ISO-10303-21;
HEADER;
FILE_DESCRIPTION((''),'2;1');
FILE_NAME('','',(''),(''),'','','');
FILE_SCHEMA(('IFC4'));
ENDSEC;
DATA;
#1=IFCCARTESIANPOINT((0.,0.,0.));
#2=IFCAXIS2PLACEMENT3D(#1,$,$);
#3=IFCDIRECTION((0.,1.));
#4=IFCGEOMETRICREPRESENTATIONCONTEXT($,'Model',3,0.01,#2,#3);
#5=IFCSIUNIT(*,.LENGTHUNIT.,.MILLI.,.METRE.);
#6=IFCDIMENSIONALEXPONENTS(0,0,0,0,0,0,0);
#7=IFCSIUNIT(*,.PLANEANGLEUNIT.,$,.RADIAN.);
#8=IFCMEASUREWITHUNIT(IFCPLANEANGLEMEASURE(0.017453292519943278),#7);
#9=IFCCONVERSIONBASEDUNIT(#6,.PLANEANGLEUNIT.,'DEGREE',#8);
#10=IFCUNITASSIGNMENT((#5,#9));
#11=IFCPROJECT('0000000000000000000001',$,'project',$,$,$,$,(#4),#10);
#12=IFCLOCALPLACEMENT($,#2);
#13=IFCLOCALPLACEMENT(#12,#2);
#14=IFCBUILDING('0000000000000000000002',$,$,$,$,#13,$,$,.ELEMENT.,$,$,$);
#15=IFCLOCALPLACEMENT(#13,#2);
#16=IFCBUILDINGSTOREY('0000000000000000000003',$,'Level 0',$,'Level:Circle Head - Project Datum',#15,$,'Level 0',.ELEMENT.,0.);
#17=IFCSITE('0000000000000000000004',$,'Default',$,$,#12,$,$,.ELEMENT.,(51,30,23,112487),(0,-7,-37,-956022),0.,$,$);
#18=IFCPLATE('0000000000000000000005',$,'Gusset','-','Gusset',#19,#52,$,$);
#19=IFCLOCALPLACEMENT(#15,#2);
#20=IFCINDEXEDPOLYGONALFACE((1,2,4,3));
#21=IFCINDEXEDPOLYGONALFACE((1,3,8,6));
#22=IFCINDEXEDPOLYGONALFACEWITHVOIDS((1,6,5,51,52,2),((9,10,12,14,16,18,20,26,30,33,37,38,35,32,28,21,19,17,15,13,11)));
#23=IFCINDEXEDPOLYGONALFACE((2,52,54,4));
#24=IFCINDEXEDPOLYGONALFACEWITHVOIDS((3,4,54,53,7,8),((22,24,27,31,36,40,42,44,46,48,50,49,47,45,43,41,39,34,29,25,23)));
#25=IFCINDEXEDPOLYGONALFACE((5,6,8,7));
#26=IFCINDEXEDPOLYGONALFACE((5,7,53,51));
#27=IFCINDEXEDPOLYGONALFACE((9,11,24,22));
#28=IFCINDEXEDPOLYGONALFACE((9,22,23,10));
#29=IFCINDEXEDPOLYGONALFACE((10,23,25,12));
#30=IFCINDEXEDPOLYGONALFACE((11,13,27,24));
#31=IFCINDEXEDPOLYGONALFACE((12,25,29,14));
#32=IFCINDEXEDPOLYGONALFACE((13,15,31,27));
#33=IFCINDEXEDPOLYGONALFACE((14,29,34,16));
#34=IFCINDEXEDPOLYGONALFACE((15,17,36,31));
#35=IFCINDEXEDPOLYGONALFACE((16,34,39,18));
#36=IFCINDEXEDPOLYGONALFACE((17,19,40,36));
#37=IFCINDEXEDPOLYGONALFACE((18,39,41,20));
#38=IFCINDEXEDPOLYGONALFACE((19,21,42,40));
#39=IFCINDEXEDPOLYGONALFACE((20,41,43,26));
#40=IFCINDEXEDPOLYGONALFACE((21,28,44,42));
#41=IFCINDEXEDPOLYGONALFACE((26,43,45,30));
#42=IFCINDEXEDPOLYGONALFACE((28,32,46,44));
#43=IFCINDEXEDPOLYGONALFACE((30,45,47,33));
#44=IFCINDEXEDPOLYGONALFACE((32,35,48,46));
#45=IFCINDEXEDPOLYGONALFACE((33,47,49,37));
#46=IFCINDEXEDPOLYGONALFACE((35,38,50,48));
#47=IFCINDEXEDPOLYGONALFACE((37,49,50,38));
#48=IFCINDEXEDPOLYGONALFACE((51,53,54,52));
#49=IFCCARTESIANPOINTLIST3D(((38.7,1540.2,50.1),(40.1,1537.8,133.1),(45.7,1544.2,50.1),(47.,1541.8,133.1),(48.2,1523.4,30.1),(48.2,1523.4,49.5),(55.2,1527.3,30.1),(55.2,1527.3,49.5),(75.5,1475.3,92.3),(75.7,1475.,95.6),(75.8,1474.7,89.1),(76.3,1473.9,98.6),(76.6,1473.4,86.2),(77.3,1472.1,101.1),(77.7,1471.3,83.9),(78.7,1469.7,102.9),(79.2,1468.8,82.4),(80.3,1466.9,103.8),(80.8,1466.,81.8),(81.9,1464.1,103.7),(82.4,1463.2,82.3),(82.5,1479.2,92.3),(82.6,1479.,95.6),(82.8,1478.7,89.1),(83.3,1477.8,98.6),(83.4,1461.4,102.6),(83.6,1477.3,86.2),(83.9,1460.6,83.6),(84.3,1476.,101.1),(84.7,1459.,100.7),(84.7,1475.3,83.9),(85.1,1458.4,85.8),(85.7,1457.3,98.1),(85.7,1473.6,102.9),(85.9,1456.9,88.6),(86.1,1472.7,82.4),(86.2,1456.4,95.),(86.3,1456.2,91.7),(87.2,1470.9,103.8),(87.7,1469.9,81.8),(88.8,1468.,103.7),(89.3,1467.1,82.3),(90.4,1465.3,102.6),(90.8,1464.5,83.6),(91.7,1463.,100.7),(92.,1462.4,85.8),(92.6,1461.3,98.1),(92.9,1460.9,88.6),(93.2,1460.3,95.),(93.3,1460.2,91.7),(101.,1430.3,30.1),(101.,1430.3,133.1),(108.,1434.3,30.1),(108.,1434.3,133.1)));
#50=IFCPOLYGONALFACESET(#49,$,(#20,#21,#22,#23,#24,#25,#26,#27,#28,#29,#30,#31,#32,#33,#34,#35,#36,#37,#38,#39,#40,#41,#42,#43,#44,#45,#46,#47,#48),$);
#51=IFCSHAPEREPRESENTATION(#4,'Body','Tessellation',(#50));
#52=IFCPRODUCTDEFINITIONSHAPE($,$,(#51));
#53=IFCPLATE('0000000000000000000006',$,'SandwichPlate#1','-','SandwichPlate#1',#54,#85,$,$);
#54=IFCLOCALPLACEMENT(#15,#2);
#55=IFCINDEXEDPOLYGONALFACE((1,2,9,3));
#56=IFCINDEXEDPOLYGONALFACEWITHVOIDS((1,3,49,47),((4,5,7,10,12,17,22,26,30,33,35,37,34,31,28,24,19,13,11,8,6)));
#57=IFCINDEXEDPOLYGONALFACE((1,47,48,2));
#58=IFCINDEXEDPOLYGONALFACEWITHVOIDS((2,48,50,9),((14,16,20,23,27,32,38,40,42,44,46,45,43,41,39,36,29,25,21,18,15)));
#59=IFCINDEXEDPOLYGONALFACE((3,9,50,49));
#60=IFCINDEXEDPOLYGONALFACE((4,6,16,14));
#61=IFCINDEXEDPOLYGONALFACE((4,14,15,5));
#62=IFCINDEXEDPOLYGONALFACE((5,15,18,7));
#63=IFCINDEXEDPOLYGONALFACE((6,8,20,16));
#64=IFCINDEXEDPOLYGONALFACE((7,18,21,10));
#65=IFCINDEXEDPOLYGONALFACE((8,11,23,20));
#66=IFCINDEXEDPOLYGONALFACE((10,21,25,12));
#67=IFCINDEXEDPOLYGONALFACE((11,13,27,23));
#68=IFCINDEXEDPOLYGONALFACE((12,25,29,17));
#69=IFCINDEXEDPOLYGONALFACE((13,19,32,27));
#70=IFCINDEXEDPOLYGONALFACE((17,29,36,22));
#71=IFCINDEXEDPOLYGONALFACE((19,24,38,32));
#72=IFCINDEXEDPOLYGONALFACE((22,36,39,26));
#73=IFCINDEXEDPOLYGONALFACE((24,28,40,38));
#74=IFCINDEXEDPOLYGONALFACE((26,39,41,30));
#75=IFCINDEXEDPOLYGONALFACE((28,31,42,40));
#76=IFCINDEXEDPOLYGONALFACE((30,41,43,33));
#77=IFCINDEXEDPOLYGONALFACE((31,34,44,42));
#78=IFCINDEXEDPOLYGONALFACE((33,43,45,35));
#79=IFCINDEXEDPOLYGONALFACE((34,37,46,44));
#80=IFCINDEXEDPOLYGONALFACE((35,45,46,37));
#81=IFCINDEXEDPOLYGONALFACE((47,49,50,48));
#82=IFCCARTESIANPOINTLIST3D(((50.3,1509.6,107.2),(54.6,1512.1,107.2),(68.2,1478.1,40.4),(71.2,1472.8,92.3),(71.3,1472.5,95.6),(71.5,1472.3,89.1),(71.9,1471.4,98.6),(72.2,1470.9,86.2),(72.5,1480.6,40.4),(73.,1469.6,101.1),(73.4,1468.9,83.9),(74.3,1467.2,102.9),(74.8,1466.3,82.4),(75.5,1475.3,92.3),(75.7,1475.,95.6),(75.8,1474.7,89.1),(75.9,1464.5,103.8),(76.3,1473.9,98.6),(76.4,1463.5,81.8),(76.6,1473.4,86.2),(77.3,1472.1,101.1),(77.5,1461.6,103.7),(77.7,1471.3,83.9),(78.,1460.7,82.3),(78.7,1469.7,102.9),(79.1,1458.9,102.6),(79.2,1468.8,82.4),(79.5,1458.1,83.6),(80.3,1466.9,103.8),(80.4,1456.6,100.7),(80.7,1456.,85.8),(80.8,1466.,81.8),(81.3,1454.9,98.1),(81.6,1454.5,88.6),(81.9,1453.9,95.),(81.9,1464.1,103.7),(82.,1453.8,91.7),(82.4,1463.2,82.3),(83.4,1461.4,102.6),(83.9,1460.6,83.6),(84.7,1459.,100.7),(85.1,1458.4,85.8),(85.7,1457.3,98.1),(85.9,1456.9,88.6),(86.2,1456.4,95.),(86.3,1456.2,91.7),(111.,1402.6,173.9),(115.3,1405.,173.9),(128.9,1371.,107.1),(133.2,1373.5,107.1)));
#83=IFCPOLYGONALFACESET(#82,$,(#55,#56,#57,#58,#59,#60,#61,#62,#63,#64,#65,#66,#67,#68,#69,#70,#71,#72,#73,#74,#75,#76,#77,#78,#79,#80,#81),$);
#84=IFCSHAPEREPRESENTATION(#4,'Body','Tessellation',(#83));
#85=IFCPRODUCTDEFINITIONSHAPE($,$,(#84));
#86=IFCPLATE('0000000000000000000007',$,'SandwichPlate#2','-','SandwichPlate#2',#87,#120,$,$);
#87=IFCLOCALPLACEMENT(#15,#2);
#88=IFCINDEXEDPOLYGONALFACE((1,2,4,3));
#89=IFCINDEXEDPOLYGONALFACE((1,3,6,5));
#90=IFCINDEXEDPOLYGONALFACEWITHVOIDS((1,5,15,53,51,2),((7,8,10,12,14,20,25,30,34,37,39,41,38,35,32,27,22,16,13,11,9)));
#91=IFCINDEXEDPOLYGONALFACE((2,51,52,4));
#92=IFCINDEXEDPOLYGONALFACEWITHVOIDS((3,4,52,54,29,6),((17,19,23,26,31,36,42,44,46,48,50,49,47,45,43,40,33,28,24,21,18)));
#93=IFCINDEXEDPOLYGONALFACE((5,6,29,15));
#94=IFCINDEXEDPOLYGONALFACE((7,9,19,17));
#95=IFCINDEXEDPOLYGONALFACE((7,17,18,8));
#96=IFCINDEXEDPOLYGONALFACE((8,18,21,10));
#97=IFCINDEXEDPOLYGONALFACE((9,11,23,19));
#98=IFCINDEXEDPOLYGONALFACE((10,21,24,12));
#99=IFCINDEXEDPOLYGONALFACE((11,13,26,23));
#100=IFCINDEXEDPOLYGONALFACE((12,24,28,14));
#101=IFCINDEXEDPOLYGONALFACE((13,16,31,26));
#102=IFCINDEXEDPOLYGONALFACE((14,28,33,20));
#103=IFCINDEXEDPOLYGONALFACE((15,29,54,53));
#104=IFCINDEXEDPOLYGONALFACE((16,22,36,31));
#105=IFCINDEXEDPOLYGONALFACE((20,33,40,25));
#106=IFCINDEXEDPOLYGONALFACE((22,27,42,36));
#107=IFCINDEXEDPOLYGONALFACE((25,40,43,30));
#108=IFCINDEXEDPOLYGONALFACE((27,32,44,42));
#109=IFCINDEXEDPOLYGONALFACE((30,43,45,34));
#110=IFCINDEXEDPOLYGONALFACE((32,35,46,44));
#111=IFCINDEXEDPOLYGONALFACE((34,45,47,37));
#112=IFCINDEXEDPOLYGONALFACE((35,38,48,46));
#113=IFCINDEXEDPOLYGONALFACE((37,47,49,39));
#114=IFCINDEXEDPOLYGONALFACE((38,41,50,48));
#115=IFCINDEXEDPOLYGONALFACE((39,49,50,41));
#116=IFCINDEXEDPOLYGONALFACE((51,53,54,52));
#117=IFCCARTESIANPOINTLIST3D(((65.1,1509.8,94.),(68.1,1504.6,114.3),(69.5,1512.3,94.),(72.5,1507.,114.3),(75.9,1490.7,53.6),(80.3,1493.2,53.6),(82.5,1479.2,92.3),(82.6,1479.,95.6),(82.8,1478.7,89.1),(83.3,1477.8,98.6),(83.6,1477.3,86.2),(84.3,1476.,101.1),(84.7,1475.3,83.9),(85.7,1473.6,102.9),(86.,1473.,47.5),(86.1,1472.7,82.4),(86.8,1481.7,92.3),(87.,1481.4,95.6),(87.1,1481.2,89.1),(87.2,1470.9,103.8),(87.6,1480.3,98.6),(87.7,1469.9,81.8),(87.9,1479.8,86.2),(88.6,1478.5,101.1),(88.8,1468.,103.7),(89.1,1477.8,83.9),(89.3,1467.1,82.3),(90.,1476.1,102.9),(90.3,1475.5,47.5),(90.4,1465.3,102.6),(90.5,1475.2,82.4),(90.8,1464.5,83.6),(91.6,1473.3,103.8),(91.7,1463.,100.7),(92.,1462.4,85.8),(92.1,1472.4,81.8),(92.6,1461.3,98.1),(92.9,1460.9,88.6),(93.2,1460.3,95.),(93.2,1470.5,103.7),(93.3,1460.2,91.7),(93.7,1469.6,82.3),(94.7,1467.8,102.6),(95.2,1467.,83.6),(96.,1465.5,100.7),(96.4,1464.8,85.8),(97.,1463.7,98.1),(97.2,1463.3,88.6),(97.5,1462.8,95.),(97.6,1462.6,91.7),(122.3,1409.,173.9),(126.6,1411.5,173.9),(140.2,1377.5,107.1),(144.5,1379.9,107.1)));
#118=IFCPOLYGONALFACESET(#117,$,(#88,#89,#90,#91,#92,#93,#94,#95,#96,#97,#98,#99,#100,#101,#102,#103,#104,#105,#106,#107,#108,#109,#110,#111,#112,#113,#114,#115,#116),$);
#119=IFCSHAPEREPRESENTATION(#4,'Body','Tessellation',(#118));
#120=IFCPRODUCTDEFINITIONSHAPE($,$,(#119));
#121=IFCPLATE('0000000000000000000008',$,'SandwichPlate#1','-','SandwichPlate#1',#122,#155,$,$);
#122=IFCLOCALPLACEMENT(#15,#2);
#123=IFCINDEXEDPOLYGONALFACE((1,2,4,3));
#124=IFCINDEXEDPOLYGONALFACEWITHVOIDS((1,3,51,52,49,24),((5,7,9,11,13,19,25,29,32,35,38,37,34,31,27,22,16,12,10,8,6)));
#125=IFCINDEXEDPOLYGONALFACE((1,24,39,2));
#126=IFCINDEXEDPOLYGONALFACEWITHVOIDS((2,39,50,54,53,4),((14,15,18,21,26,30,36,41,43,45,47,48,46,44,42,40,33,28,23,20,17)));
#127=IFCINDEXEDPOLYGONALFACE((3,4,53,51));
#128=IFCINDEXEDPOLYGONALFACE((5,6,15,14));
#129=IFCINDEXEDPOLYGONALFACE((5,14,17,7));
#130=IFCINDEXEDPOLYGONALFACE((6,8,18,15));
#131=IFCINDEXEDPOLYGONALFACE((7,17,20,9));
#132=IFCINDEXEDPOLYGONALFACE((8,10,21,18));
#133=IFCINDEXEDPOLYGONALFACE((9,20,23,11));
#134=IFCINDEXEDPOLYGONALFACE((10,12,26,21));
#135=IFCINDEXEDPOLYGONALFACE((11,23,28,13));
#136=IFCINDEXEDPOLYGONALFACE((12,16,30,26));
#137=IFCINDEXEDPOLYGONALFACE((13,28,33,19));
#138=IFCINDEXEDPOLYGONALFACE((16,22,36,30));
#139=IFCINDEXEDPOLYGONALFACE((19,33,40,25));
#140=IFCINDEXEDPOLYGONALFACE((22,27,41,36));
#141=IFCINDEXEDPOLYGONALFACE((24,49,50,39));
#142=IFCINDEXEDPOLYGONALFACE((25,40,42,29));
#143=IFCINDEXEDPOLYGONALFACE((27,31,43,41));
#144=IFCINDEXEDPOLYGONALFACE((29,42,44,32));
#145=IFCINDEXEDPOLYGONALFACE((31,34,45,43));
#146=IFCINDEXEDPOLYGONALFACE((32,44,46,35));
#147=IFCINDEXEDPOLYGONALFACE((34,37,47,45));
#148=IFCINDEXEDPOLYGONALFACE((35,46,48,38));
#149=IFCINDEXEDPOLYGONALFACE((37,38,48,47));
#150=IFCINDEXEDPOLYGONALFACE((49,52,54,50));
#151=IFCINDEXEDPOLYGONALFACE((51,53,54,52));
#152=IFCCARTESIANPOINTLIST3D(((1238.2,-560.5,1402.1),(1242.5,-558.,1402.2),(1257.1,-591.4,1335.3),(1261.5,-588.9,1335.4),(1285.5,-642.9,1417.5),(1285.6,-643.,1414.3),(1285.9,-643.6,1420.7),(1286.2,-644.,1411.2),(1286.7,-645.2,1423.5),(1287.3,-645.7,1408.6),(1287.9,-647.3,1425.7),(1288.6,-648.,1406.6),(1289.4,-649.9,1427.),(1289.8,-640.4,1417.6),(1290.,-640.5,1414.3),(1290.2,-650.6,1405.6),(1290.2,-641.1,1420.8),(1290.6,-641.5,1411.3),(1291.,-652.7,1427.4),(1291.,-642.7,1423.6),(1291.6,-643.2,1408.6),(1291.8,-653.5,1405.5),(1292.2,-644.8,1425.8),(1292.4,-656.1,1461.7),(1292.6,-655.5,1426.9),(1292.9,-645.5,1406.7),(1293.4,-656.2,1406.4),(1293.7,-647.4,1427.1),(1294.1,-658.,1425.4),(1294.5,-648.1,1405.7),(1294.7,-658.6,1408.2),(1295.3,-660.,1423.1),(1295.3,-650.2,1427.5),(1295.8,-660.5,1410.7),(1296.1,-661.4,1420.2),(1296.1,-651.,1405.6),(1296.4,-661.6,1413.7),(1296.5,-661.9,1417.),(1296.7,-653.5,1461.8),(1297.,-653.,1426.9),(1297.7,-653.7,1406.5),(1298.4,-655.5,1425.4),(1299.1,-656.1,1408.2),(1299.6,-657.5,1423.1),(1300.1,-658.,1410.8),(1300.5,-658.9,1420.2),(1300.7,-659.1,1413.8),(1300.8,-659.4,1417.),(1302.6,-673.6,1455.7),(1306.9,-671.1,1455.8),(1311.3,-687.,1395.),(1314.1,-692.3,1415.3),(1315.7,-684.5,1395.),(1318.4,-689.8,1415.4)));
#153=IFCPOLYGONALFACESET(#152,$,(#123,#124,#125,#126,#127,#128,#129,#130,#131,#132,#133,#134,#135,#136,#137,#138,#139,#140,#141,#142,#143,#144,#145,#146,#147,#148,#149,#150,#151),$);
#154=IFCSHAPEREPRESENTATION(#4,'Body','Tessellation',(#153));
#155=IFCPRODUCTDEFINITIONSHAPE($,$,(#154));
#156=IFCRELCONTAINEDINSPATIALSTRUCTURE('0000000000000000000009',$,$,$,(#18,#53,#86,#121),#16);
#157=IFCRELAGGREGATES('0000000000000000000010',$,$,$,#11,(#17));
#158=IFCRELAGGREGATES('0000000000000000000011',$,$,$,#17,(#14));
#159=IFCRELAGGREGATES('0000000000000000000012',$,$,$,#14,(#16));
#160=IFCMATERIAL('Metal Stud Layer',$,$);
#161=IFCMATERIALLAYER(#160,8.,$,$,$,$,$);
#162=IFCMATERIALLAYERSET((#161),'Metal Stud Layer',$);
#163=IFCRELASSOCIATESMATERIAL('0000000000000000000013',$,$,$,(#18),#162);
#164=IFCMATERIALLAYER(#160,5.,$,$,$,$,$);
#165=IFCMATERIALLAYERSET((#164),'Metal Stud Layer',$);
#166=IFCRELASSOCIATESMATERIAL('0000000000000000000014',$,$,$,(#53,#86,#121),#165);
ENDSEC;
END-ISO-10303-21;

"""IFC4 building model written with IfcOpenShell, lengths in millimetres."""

from ifc_helpers import new_model, entity, si_unit, converted_unit, point, direction, frame, frame_2d, origin, origin_with_axes, origin_2d_with_axis, place, context, project, spatial, polyline, circle_curve, line_curve, trimmed, segment, composite_curve, circle, outline, extrude, material, layer, layer_set, element, save


model = new_model("IFC4")

# Units and contexts
model_context = context("Model", 3, precision=0.01, world=origin(), true_north=direction((0.0, 1.0)))
ifc_project = project(units=[si_unit("LENGTHUNIT", "METRE", prefix="MILLI"), converted_unit("PLANEANGLEUNIT", "DEGREE", entity("IfcPlaneAngleMeasure", 0.017453292519943278), si_unit("PLANEANGLEUNIT", "RADIAN"), dimensions=[0, 0, 0, 0, 0, 0, 0])], contexts=[model_context])

# Site, building, storey
site_placement = place(None, origin())
site = spatial("IfcSite", under=ifc_project, at=site_placement, Name="Default", CompositionType="ELEMENT", RefLatitude=(51, 30, 23, 112487), RefLongitude=(0, -7, -37, -956022), RefElevation=0.0)
building_placement = place(site_placement, origin())
building = spatial("IfcBuilding", under=site, at=building_placement, CompositionType="ELEMENT")
storey_placement = place(building_placement, origin())
storey = spatial("IfcBuildingStorey", under=building, at=storey_placement, Name="Level 0", ObjectType="Level:Circle Head - Project Datum", LongName="Level 0", CompositionType="ELEMENT", Elevation=0.0)

# Shared definitions
ifc_material_1 = material(Name="Metal Stud Layer")
ifc_layer_1 = layer(ifc_material_1, 8.0)
ifc_layer_set_1 = layer_set([ifc_layer_1], Name="Metal Stud Layer")

# Shared definitions
ifc_layer_2 = layer(ifc_material_1, 5.0)
ifc_layer_set_2 = layer_set([ifc_layer_2], Name="Metal Stud Layer")

# Plate, openings
plate_1_placement = place(storey_placement, frame((41.3, 1535.6, 143.5), z_axis=(0.869914, 0.493203, 0.0), x_axis=(0.492931, -0.869436, -0.033166)))
plate_1 = element("IfcPlate", 1, at=plate_1_placement, inside=storey, material=ifc_layer_set_1, Name="Gusset", Description="-", ObjectType="Gusset", context=model_context, shape_type="SweptSolid", body=[
    extrude(outline(polyline([(17.1, 93.5), (-2.2, 93.5), (-2.2, 10.5), (121.3, 6.4), (124.7, 109.3), (17.8, 112.9), (17.1, 93.5)])), origin_with_axes(), (0.0, 0.0, 1.0), 8.0),
])
opening_1_placement = place(plate_1_placement, origin_with_axes())
element("IfcOpeningElement", 2, at=opening_1_placement, cuts=plate_1, ObjectType="Opening", context=model_context, shape_type="SweptSolid", body=[
    extrude(outline(composite_curve([segment(trimmed(line_curve((17.1, 93.5), (-1.0, 0.0), 19.347323), [point((17.1, 93.5))], [point((-2.2, 93.5))], True, "CARTESIAN"), True, "CONTINUOUS"), segment(trimmed(circle_curve(frame_2d((-2.2, 113.5), x_axis=(1.0, 0.0)), 20.0), [point((-2.2, 93.5))], [point((17.8, 112.9))], True, "CARTESIAN"), True, "CONTINUOUS"), segment(trimmed(line_curve((17.8, 112.9), (-0.033166, -0.99945), 19.347323), [point((17.8, 112.9))], [point((17.1, 93.5))], True, "CARTESIAN"), True, "CONTINUOUS")], self_intersect="UNKNOWN")), origin(), (0.0, 0.0, 1.0), 8.0),
])
opening_2_placement = place(plate_1_placement, frame((81.9, 48.0, 8.5), z_axis=(0.0, 0.0, -1.0), x_axis=(0.862665, -0.505775, 0.0)))
element("IfcOpeningElement", 3, at=opening_2_placement, cuts=plate_1, ObjectType="Opening", context=model_context, shape_type="SweptSolid", body=[
    extrude(circle(Radius=11.0, at=origin_2d_with_axis()), origin(), (0.0, 0.0, 1.0), 9.0),
])

# Plates, openings
plate_2_placement = place(storey_placement, frame((54.6, 1512.1, 107.2), z_axis=(-0.869914, -0.493203, 0.0), x_axis=(0.235201, -0.41485, -0.878965)))
plate_2 = element("IfcPlate", 4, at=plate_2_placement, inside=storey, material=ifc_layer_set_2, Name="SandwichPlate#1", Description="-", ObjectType="SandwichPlate#1", context=model_context, shape_type="SweptSolid", body=[
    extrude(outline(polyline([(0.0, 0.0), (76.0, 0.0), (76.0, 140.0), (0.0, 140.0), (0.0, 0.0)])), origin_with_axes(), (0.0, 0.0, 1.0), 5.0),
])
opening_3_placement = place(plate_2_placement, frame((38.0, 40.0, -0.5), z_axis=(0.0, 0.0, 1.0), x_axis=(0.0, 1.0, 0.0)))
element("IfcOpeningElement", 5, at=opening_3_placement, cuts=plate_2, ObjectType="Opening", context=model_context, shape_type="SweptSolid", body=[
    extrude(circle(Radius=11.0, at=origin_2d_with_axis()), origin(), (0.0, 0.0, 1.0), 6.0),
])
plate_3_placement = place(storey_placement, frame((66.0, 1518.5, 107.2), z_axis=(-0.869914, -0.493203, 0.0), x_axis=(0.235201, -0.41485, -0.878965)))
plate_3 = element("IfcPlate", 6, at=plate_3_placement, inside=storey, material=ifc_layer_set_2, Name="SandwichPlate#2", Description="-", ObjectType="SandwichPlate#2", context=model_context, shape_type="SweptSolid", body=[
    extrude(outline(polyline([(15.0, 0.0), (61.0, 0.0), (76.0, 15.0), (76.0, 140.0), (0.0, 140.0), (0.0, 15.0), (15.0, 0.0)])), origin_with_axes(), (0.0, 0.0, 1.0), 5.0),
])
opening_4_placement = place(plate_3_placement, frame((38.0, 40.0, -0.5), z_axis=(0.0, 0.0, 1.0), x_axis=(0.0, 1.0, 0.0)))
element("IfcOpeningElement", 7, at=opening_4_placement, cuts=plate_3, ObjectType="Opening", context=model_context, shape_type="SweptSolid", body=[
    extrude(circle(Radius=11.0, at=origin_2d_with_axis()), origin(), (0.0, 0.0, 1.0), 6.0),
])

# Plate, openings
plate_4_placement = place(storey_placement, frame((1322.2, -695.9, 1402.2), z_axis=(-0.865935, -0.499948, -0.014432), x_axis=(-0.249453, 0.406695, 0.878847)))
plate_4 = element("IfcPlate", 8, at=plate_4_placement, inside=storey, material=ifc_layer_set_2, Name="SandwichPlate#1", Description="-", ObjectType="SandwichPlate#1", context=model_context, shape_type="SweptSolid", body=[
    extrude(outline(polyline([(0.0, 0.0), (76.0, 0.0), (76.0, 140.0), (0.0, 140.0), (0.0, 0.0)])), origin_with_axes(), (0.0, 0.0, 1.0), 5.0),
])
opening_5_placement = place(plate_4_placement, frame((0.0, 0.0, 0.0), z_axis=(0.0, 0.0, 1.0), x_axis=(1.0, 0.0, 0.0)))
element("IfcOpeningElement", 9, at=opening_5_placement, cuts=plate_4, ObjectType="Opening", context=model_context, shape_type="SweptSolid", body=[
    extrude(outline(polyline([(0.0, 0.0), (15.0, 0.0), (0.0, 15.0), (0.0, 0.0)])), origin(), (0.0, 0.0, 1.0), 5.0),
])
opening_6_placement = place(plate_4_placement, frame((0.0, 0.0, 0.0), z_axis=(0.0, 0.0, 1.0), x_axis=(1.0, 0.0, 0.0)))
element("IfcOpeningElement", 10, at=opening_6_placement, cuts=plate_4, ObjectType="Opening", context=model_context, shape_type="SweptSolid", body=[
    extrude(outline(polyline([(76.0, 0.0), (76.0, 15.0), (61.0, 0.0), (76.0, 0.0)])), origin(), (0.0, 0.0, 1.0), 5.0),
])
opening_7_placement = place(plate_4_placement, frame((38.0, 40.0, -0.5), z_axis=(0.0, 0.0, 1.0), x_axis=(0.0, 1.0, 0.0)))
element("IfcOpeningElement", 11, at=opening_7_placement, cuts=plate_4, ObjectType="Opening", context=model_context, shape_type="SweptSolid", body=[
    extrude(circle(Radius=11.0, at=origin_2d_with_axis()), origin(), (0.0, 0.0, 1.0), 6.0),
])

save(model, "model.ifc")
